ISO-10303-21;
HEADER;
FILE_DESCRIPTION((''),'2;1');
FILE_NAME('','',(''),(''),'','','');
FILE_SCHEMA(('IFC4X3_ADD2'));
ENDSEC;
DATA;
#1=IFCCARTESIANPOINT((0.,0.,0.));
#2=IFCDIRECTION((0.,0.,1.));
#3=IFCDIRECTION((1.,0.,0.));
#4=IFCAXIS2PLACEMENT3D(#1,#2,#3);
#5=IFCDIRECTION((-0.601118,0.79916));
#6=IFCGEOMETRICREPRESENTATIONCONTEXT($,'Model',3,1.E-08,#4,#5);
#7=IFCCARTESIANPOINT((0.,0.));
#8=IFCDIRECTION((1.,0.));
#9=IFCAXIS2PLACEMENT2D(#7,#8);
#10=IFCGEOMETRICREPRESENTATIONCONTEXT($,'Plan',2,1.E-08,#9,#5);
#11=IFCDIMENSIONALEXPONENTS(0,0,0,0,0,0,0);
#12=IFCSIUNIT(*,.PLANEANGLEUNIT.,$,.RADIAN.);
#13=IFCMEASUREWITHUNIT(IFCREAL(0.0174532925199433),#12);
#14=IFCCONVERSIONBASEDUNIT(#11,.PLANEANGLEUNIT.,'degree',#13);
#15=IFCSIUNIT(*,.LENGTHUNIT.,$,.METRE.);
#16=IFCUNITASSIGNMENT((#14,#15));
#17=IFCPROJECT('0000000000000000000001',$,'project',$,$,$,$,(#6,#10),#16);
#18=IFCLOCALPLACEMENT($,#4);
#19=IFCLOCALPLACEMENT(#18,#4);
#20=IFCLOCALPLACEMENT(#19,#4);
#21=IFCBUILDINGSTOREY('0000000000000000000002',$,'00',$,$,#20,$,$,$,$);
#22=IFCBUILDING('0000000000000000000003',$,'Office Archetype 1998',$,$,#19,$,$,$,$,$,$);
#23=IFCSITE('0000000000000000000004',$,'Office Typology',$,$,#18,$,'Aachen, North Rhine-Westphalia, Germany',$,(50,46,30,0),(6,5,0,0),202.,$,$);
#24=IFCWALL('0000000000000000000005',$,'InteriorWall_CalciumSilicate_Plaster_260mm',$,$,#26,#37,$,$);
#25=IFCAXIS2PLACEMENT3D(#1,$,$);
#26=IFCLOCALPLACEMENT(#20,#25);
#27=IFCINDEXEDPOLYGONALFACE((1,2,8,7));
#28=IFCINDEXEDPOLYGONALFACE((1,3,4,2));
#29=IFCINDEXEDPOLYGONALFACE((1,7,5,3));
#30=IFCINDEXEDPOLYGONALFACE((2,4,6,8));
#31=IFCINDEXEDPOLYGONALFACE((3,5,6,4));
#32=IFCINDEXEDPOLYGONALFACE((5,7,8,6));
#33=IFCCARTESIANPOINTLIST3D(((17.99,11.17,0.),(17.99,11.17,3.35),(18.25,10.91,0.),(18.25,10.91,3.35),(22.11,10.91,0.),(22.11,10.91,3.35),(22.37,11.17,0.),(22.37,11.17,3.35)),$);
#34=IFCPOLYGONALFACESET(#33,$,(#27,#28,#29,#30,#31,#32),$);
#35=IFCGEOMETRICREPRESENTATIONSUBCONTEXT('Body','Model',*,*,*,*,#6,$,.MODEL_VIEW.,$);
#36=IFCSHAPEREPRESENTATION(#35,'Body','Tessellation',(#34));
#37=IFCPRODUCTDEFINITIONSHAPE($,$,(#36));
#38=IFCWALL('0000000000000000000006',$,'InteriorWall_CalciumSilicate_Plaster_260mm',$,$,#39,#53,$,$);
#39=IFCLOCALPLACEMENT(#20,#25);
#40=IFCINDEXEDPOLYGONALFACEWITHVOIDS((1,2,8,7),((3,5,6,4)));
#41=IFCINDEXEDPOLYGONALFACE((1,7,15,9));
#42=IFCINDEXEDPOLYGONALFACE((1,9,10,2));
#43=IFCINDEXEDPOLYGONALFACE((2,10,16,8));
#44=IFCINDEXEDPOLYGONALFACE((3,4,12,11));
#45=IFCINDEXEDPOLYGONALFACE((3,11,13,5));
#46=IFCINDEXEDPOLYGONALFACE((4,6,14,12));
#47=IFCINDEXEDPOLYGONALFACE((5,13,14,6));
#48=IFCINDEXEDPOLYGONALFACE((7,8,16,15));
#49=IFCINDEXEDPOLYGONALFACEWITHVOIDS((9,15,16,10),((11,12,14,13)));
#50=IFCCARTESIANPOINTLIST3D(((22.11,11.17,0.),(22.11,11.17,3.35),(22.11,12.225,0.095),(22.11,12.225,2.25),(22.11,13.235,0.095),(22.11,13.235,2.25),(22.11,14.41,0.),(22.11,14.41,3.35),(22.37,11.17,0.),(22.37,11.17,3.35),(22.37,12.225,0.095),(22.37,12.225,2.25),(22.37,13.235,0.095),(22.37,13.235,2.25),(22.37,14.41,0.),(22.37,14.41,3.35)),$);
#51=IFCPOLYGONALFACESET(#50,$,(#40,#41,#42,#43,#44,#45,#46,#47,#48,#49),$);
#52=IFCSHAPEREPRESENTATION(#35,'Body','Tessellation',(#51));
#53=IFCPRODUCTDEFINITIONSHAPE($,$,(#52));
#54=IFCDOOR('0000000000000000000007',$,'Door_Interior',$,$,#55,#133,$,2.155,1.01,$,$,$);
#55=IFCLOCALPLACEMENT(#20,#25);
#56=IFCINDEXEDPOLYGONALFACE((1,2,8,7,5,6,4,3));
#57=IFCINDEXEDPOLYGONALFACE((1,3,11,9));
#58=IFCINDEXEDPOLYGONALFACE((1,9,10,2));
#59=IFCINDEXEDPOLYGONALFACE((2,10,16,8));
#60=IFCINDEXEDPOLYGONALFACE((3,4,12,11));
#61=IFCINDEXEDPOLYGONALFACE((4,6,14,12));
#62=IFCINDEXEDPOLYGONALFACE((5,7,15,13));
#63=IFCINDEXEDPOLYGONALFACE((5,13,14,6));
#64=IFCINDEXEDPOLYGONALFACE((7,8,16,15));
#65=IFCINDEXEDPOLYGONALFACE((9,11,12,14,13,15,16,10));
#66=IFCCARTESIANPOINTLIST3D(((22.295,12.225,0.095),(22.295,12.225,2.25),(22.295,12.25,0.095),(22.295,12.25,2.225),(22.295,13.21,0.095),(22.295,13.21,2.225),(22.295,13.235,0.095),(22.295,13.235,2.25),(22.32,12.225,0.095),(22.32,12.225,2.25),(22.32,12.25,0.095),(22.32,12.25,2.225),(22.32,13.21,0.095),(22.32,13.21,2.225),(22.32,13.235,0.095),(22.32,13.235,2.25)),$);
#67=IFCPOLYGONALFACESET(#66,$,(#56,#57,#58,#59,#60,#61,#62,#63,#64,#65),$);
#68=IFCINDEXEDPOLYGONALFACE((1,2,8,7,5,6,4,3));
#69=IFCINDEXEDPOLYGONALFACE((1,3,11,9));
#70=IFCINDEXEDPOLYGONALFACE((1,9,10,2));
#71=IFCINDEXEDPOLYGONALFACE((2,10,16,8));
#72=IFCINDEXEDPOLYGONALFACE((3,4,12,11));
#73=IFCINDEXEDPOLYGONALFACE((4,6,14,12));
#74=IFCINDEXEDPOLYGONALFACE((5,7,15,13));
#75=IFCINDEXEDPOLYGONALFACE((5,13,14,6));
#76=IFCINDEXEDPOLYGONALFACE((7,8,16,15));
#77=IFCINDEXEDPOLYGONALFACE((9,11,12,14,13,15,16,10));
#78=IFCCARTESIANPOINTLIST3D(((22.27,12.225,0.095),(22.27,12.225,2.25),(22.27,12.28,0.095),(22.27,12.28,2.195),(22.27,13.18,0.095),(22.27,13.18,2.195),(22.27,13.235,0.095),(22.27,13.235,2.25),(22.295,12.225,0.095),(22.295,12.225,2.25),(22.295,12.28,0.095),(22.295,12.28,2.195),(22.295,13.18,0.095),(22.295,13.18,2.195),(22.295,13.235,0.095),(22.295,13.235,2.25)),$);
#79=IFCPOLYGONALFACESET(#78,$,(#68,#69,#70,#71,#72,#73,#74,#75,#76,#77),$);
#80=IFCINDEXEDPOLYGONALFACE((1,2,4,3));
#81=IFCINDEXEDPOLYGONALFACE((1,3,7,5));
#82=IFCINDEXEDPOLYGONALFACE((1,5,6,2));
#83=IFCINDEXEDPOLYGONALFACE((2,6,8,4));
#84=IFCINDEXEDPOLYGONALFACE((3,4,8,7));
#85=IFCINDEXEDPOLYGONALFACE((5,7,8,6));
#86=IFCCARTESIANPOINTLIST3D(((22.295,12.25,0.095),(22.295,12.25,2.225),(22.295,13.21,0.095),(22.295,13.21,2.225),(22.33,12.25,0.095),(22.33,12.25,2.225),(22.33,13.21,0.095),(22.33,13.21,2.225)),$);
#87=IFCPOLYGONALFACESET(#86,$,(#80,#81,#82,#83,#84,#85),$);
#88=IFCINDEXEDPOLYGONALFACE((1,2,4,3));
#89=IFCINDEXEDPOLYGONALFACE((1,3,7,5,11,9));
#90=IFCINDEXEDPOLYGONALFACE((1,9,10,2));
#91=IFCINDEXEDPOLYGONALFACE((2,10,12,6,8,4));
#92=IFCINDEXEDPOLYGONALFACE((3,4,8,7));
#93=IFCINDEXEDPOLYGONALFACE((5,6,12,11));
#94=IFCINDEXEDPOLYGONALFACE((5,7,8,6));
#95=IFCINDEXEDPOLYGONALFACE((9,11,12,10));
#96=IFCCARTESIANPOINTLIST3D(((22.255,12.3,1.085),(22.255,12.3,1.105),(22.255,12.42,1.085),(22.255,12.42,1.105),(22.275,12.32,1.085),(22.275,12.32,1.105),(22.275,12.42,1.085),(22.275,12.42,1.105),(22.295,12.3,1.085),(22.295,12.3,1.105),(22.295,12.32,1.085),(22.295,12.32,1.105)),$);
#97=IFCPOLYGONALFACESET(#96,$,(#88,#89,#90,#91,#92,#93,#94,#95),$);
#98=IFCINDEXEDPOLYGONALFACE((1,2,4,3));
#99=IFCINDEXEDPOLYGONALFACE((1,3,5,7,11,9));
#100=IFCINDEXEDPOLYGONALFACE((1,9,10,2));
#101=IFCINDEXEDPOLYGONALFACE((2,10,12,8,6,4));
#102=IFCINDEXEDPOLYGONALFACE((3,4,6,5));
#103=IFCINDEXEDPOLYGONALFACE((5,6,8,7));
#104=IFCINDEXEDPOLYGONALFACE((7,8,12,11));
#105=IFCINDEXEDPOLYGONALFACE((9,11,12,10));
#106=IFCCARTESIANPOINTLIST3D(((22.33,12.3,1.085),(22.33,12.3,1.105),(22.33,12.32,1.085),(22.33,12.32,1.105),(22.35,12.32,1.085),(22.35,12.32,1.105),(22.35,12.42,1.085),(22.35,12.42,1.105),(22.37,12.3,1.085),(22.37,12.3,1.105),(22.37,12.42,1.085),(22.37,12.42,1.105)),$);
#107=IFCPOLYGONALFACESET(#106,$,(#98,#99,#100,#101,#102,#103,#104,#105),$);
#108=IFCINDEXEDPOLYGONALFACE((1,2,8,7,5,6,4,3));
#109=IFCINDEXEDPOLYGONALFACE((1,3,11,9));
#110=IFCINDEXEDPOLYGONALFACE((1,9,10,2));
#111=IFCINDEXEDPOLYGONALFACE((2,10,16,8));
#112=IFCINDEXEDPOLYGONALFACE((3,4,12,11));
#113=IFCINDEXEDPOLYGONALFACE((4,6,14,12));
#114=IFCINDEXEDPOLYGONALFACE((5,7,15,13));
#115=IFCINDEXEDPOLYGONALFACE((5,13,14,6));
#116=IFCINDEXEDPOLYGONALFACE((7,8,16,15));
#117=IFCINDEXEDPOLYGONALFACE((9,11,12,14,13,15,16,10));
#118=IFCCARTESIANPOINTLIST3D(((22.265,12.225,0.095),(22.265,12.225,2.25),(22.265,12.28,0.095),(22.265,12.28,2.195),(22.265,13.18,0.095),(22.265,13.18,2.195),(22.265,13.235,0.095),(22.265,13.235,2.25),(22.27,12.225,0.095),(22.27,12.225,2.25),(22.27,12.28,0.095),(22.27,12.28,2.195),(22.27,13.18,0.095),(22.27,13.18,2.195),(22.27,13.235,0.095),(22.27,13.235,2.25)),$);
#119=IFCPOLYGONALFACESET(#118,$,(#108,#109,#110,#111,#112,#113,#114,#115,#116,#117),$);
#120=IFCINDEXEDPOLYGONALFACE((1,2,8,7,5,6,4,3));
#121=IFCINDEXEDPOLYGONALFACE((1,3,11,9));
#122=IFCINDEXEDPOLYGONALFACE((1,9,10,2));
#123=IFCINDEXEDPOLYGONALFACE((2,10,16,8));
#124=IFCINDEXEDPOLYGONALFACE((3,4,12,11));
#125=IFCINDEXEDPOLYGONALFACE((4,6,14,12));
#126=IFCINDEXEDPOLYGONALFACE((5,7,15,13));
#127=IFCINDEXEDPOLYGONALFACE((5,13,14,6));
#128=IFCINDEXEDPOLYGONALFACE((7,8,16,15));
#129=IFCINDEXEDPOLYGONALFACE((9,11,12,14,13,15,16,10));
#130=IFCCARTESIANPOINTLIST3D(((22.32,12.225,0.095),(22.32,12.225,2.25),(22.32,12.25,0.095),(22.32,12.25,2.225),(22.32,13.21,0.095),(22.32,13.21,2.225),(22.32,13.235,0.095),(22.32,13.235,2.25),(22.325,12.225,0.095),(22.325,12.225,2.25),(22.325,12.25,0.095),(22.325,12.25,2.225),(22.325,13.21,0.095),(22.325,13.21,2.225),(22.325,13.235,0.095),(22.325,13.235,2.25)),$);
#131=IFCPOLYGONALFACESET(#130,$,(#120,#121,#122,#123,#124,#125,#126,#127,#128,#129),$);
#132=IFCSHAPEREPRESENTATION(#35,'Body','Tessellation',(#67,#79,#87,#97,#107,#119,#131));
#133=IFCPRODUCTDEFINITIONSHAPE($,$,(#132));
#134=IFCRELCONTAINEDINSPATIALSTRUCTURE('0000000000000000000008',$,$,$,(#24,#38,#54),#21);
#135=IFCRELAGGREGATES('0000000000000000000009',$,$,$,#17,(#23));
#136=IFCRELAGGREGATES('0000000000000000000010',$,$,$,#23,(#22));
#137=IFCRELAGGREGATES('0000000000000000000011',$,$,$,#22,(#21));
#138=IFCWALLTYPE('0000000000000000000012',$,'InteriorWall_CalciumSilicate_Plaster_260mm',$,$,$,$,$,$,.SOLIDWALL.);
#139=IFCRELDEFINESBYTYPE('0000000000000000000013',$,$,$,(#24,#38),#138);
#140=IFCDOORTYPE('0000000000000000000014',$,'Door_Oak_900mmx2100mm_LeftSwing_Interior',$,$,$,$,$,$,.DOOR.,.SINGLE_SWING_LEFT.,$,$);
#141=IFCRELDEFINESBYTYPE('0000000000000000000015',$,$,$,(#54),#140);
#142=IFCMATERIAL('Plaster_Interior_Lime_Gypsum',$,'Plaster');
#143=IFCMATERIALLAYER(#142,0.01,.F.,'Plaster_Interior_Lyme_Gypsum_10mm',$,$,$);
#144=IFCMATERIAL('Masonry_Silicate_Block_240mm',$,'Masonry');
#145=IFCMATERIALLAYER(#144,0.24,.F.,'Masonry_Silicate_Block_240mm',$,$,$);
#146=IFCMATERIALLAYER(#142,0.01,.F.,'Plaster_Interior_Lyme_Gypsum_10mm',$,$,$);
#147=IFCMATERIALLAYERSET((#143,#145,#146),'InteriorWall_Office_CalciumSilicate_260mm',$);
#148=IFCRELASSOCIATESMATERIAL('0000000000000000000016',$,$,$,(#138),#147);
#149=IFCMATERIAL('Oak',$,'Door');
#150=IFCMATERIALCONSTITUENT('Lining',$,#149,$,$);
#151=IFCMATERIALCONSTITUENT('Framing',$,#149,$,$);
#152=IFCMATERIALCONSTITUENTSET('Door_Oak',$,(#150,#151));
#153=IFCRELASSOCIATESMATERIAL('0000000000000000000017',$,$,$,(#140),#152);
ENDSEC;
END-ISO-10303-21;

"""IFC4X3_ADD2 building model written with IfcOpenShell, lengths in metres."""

from ifc_helpers import new_model, entity, si_unit, converted_unit, direction, frame, origin_with_axes, origin_2d_with_axis, place, context, subcontext, project, spatial, line, indexed_curve, outline, extrude, source, transform, mapped, material, layer, layer_set, constituent, constituent_set, type_object, type_shapes, element, fill, save


model = new_model("IFC4X3_ADD2")

# Units and contexts
model_context = context("Model", 3, precision=1e-08, world=origin_with_axes(), true_north=direction((-0.601118, 0.79916)))
plan_context = context("Plan", 2, precision=1e-08, world=origin_2d_with_axis(), true_north=direction((-0.601118, 0.79916)))
body_context = subcontext(model_context, "Body", "Model", "MODEL_VIEW")
ifc_project = project(units=[converted_unit("PLANEANGLEUNIT", "degree", entity("IfcReal", 0.0174532925199433), si_unit("PLANEANGLEUNIT", "RADIAN"), dimensions=[0, 0, 0, 0, 0, 0, 0]), si_unit("LENGTHUNIT", "METRE")], contexts=[model_context, plan_context])

# Site, building, storey
site_placement = place(None, origin_with_axes())
site = spatial("IfcSite", under=ifc_project, at=site_placement, Name="Office Typology", LongName="Aachen, North Rhine-Westphalia, Germany", RefLatitude=(50, 46, 30, 0), RefLongitude=(6, 5, 0, 0), RefElevation=202.0)
building_placement = place(site_placement, origin_with_axes())
building = spatial("IfcBuilding", under=site, at=building_placement, Name="Office Archetype 1998")
storey_placement = place(building_placement, origin_with_axes())
storey = spatial("IfcBuildingStorey", under=building, at=storey_placement, Name="00")

# Wall
ifc_material_1 = material(Name="Plaster_Interior_Lime_Gypsum", Category="Plaster")
ifc_layer_1 = layer(ifc_material_1, 0.01, ventilated=False, Name="Plaster_Interior_Lyme_Gypsum_10mm")
ifc_material_2 = material(Name="Masonry_Silicate_Block_240mm", Category="Masonry")
ifc_layer_2 = layer(ifc_material_2, 0.24, ventilated=False, Name="Masonry_Silicate_Block_240mm")
ifc_layer_3 = layer(ifc_material_1, 0.01, ventilated=False, Name="Plaster_Interior_Lyme_Gypsum_10mm")
ifc_layer_set = layer_set([ifc_layer_1, ifc_layer_2, ifc_layer_3], Name="InteriorWall_Office_CalciumSilicate_260mm")
wall_type = type_object("IfcWallType", Name="InteriorWall_CalciumSilicate_Plaster_260mm", PredefinedType="SOLIDWALL", material=ifc_layer_set)
wall_1_placement = place(storey_placement, frame((22.37, 11.17, 0.0), z_axis=(0.0, 0.0, 1.0), x_axis=(-1.0, 0.0, 0.0)))
element("IfcWall", 1, at=wall_1_placement, inside=storey, type_object=wall_type, Name="InteriorWall_CalciumSilicate_Plaster_260mm", context=body_context, shape_type="SweptSolid", body=[
    extrude(outline(indexed_curve([(0.0, 0.0), (0.26, 0.26), (4.12, 0.26), (4.38, 0.0)], segments=[line(1, 2, 3, 4, 1)])), origin_with_axes(), (0.0, 0.0, 1.0), 3.35),
])

# Wall, opening, door
wall_2_placement = place(storey_placement, frame((22.37, 11.17, 0.0), z_axis=(0.0, 0.0, 1.0), x_axis=(0.0, 1.0, 0.0)))
wall_2 = element("IfcWall", 2, at=wall_2_placement, inside=storey, type_object=wall_type, Name="InteriorWall_CalciumSilicate_Plaster_260mm", context=body_context, shape_type="SweptSolid", body=[
    extrude(outline(indexed_curve([(0.0, 0.0), (0.0, 0.26), (3.24, 0.26), (3.24, 0.0)], segments=[line(1, 2, 3, 4, 1)])), origin_with_axes(), (0.0, 0.0, 1.0), 3.35),
])
shared_shape_1 = source(origin_with_axes(), body_context, "Body", "SweptSolid", [
    extrude(outline(indexed_curve([(0.0, 2.155), (1.01, 2.155), (1.01, 0.0), (0.0, 0.0), (0.0, 2.155)])), frame((0.0, -0.015, 0.0), z_axis=(0.0, -1.0, 0.0), x_axis=(1.0, 0.0, 0.0)), (0.0, 0.0, -1.0), 0.26),
])
opening_1_placement = place(wall_2_placement, frame((2.065, 0.245, 0.095), z_axis=(0.0, 0.0, 1.0), x_axis=(-1.0, 0.0, 0.0)))
opening_1 = element("IfcOpeningElement", 3, at=opening_1_placement, cuts=wall_2, PredefinedType="OPENING", context=body_context, shape_type="MappedRepresentation", body=[
    mapped(shared_shape_1, transform((0.0, 0.0, 0.0), x_axis=(1.0, 0.0, 0.0), y_axis=(0.0, 1.0, 0.0), z_axis=(0.0, 0.0, 1.0), scale=1.0)),
])
ifc_material_3 = material(Name="Oak", Category="Door")
ifc_constituent_1 = constituent(ifc_material_3, Name="Lining")
ifc_constituent_2 = constituent(ifc_material_3, Name="Framing")
ifc_constituent_set_1 = constituent_set(constituents=[ifc_constituent_1, ifc_constituent_2], Name="Door_Oak")
door_type_1 = type_object("IfcDoorType", Name="Door_Oak_900mmx2100mm_LeftSwing_Interior", OperationType="SINGLE_SWING_LEFT", PredefinedType="DOOR", material=ifc_constituent_set_1)
shared_shape_2 = source(origin_with_axes(), body_context, "Body", "SweptSolid", [
    extrude(outline(indexed_curve([(0.0, 0.0), (0.0, 2.155), (1.01, 2.155), (1.01, 0.0), (0.985, 0.0), (0.985, 2.13), (0.025, 2.13), (0.025, 0.0)], segments=[line(1, 2, 3, 4, 5, 6, 7, 8, 1)])), frame((0.0, 0.025, 0.0), z_axis=(0.0, -1.0, 0.0), x_axis=(1.0, 0.0, 0.0)), (0.0, 0.0, -1.0), 0.025),
    extrude(outline(indexed_curve([(0.0, 0.0), (0.0, 2.155), (1.01, 2.155), (1.01, 0.0), (0.955, 0.0), (0.955, 2.1), (0.055, 2.1), (0.055, 0.0)], segments=[line(1, 2, 3, 4, 5, 6, 7, 8, 1)])), frame((0.0, 0.0, 0.0), z_axis=(0.0, -1.0, 0.0), x_axis=(1.0, 0.0, 0.0)), (0.0, 0.0, -1.0), 0.025),
    extrude(outline(indexed_curve([(0.0, 0.0), (0.96, 0.0), (0.96, 0.035), (0.0, 0.035)], segments=[line(1, 2, 3, 4, 1)])), frame((0.025, 0.025, 0.0), z_axis=(0.0, 0.0, 1.0), x_axis=(1.0, 0.0, 0.0)), (0.0, 0.0, 1.0), 2.13),
    extrude(outline(indexed_curve([(0.0, 0.0), (0.0, -0.04), (-0.12, -0.04), (-0.12, -0.02), (-0.02, -0.02), (-0.02, 0.0)], segments=[line(1, 2, 3, 4, 5, 6, 1)])), frame((0.935, 0.025, 0.99), z_axis=(0.0, 0.0, 1.0), x_axis=(1.0, 0.0, 0.0)), (0.0, 0.0, 1.0), 0.02),
    extrude(outline(indexed_curve([(0.0, 0.0), (0.0, 0.04), (-0.12, 0.04), (-0.12, 0.02), (-0.02, 0.02), (-0.02, 0.0)], segments=[line(1, 2, 3, 4, 5, 6, 1)])), frame((0.935, 0.06, 0.99), z_axis=(0.0, 0.0, 1.0), x_axis=(1.0, 0.0, 0.0)), (0.0, 0.0, 1.0), 0.02),
    extrude(outline(indexed_curve([(0.0, 0.0), (0.0, 2.155), (1.01, 2.155), (1.01, 0.0), (0.955, 0.0), (0.955, 2.1), (0.055, 2.1), (0.055, 0.0)], segments=[line(1, 2, 3, 4, 5, 6, 7, 8, 1)])), frame((0.0, -0.005, 0.0), z_axis=(0.0, -1.0, 0.0), x_axis=(1.0, 0.0, 0.0)), (0.0, 0.0, -1.0), 0.005),
    extrude(outline(indexed_curve([(0.0, 0.0), (0.0, 2.155), (1.01, 2.155), (1.01, 0.0), (0.985, 0.0), (0.985, 2.13), (0.025, 2.13), (0.025, 0.0)], segments=[line(1, 2, 3, 4, 5, 6, 7, 8, 1)])), frame((0.0, 0.05, 0.0), z_axis=(0.0, -1.0, 0.0), x_axis=(1.0, 0.0, 0.0)), (0.0, 0.0, -1.0), 0.005),
])
type_shapes(door_type_1, [shared_shape_2])
door_1_placement = place(opening_1_placement, frame((0.0, 0.145, 0.0), z_axis=(0.0, 0.0, 1.0), x_axis=(1.0, 0.0, 0.0)))
door_1 = element("IfcDoor", 4, at=door_1_placement, inside=storey, type_object=door_type_1, Name="Door_Interior", OverallHeight=2.155, OverallWidth=1.01, context=body_context, shape_type="MappedRepresentation", body=[
    mapped(shared_shape_2, transform((0.0, 0.0, 0.0), x_axis=(1.0, 0.0, 0.0), y_axis=(0.0, 1.0, 0.0), z_axis=(0.0, 0.0, 1.0), scale=1.0)),
])
fill(opening_1, door_1)

save(model, "model.ifc")
